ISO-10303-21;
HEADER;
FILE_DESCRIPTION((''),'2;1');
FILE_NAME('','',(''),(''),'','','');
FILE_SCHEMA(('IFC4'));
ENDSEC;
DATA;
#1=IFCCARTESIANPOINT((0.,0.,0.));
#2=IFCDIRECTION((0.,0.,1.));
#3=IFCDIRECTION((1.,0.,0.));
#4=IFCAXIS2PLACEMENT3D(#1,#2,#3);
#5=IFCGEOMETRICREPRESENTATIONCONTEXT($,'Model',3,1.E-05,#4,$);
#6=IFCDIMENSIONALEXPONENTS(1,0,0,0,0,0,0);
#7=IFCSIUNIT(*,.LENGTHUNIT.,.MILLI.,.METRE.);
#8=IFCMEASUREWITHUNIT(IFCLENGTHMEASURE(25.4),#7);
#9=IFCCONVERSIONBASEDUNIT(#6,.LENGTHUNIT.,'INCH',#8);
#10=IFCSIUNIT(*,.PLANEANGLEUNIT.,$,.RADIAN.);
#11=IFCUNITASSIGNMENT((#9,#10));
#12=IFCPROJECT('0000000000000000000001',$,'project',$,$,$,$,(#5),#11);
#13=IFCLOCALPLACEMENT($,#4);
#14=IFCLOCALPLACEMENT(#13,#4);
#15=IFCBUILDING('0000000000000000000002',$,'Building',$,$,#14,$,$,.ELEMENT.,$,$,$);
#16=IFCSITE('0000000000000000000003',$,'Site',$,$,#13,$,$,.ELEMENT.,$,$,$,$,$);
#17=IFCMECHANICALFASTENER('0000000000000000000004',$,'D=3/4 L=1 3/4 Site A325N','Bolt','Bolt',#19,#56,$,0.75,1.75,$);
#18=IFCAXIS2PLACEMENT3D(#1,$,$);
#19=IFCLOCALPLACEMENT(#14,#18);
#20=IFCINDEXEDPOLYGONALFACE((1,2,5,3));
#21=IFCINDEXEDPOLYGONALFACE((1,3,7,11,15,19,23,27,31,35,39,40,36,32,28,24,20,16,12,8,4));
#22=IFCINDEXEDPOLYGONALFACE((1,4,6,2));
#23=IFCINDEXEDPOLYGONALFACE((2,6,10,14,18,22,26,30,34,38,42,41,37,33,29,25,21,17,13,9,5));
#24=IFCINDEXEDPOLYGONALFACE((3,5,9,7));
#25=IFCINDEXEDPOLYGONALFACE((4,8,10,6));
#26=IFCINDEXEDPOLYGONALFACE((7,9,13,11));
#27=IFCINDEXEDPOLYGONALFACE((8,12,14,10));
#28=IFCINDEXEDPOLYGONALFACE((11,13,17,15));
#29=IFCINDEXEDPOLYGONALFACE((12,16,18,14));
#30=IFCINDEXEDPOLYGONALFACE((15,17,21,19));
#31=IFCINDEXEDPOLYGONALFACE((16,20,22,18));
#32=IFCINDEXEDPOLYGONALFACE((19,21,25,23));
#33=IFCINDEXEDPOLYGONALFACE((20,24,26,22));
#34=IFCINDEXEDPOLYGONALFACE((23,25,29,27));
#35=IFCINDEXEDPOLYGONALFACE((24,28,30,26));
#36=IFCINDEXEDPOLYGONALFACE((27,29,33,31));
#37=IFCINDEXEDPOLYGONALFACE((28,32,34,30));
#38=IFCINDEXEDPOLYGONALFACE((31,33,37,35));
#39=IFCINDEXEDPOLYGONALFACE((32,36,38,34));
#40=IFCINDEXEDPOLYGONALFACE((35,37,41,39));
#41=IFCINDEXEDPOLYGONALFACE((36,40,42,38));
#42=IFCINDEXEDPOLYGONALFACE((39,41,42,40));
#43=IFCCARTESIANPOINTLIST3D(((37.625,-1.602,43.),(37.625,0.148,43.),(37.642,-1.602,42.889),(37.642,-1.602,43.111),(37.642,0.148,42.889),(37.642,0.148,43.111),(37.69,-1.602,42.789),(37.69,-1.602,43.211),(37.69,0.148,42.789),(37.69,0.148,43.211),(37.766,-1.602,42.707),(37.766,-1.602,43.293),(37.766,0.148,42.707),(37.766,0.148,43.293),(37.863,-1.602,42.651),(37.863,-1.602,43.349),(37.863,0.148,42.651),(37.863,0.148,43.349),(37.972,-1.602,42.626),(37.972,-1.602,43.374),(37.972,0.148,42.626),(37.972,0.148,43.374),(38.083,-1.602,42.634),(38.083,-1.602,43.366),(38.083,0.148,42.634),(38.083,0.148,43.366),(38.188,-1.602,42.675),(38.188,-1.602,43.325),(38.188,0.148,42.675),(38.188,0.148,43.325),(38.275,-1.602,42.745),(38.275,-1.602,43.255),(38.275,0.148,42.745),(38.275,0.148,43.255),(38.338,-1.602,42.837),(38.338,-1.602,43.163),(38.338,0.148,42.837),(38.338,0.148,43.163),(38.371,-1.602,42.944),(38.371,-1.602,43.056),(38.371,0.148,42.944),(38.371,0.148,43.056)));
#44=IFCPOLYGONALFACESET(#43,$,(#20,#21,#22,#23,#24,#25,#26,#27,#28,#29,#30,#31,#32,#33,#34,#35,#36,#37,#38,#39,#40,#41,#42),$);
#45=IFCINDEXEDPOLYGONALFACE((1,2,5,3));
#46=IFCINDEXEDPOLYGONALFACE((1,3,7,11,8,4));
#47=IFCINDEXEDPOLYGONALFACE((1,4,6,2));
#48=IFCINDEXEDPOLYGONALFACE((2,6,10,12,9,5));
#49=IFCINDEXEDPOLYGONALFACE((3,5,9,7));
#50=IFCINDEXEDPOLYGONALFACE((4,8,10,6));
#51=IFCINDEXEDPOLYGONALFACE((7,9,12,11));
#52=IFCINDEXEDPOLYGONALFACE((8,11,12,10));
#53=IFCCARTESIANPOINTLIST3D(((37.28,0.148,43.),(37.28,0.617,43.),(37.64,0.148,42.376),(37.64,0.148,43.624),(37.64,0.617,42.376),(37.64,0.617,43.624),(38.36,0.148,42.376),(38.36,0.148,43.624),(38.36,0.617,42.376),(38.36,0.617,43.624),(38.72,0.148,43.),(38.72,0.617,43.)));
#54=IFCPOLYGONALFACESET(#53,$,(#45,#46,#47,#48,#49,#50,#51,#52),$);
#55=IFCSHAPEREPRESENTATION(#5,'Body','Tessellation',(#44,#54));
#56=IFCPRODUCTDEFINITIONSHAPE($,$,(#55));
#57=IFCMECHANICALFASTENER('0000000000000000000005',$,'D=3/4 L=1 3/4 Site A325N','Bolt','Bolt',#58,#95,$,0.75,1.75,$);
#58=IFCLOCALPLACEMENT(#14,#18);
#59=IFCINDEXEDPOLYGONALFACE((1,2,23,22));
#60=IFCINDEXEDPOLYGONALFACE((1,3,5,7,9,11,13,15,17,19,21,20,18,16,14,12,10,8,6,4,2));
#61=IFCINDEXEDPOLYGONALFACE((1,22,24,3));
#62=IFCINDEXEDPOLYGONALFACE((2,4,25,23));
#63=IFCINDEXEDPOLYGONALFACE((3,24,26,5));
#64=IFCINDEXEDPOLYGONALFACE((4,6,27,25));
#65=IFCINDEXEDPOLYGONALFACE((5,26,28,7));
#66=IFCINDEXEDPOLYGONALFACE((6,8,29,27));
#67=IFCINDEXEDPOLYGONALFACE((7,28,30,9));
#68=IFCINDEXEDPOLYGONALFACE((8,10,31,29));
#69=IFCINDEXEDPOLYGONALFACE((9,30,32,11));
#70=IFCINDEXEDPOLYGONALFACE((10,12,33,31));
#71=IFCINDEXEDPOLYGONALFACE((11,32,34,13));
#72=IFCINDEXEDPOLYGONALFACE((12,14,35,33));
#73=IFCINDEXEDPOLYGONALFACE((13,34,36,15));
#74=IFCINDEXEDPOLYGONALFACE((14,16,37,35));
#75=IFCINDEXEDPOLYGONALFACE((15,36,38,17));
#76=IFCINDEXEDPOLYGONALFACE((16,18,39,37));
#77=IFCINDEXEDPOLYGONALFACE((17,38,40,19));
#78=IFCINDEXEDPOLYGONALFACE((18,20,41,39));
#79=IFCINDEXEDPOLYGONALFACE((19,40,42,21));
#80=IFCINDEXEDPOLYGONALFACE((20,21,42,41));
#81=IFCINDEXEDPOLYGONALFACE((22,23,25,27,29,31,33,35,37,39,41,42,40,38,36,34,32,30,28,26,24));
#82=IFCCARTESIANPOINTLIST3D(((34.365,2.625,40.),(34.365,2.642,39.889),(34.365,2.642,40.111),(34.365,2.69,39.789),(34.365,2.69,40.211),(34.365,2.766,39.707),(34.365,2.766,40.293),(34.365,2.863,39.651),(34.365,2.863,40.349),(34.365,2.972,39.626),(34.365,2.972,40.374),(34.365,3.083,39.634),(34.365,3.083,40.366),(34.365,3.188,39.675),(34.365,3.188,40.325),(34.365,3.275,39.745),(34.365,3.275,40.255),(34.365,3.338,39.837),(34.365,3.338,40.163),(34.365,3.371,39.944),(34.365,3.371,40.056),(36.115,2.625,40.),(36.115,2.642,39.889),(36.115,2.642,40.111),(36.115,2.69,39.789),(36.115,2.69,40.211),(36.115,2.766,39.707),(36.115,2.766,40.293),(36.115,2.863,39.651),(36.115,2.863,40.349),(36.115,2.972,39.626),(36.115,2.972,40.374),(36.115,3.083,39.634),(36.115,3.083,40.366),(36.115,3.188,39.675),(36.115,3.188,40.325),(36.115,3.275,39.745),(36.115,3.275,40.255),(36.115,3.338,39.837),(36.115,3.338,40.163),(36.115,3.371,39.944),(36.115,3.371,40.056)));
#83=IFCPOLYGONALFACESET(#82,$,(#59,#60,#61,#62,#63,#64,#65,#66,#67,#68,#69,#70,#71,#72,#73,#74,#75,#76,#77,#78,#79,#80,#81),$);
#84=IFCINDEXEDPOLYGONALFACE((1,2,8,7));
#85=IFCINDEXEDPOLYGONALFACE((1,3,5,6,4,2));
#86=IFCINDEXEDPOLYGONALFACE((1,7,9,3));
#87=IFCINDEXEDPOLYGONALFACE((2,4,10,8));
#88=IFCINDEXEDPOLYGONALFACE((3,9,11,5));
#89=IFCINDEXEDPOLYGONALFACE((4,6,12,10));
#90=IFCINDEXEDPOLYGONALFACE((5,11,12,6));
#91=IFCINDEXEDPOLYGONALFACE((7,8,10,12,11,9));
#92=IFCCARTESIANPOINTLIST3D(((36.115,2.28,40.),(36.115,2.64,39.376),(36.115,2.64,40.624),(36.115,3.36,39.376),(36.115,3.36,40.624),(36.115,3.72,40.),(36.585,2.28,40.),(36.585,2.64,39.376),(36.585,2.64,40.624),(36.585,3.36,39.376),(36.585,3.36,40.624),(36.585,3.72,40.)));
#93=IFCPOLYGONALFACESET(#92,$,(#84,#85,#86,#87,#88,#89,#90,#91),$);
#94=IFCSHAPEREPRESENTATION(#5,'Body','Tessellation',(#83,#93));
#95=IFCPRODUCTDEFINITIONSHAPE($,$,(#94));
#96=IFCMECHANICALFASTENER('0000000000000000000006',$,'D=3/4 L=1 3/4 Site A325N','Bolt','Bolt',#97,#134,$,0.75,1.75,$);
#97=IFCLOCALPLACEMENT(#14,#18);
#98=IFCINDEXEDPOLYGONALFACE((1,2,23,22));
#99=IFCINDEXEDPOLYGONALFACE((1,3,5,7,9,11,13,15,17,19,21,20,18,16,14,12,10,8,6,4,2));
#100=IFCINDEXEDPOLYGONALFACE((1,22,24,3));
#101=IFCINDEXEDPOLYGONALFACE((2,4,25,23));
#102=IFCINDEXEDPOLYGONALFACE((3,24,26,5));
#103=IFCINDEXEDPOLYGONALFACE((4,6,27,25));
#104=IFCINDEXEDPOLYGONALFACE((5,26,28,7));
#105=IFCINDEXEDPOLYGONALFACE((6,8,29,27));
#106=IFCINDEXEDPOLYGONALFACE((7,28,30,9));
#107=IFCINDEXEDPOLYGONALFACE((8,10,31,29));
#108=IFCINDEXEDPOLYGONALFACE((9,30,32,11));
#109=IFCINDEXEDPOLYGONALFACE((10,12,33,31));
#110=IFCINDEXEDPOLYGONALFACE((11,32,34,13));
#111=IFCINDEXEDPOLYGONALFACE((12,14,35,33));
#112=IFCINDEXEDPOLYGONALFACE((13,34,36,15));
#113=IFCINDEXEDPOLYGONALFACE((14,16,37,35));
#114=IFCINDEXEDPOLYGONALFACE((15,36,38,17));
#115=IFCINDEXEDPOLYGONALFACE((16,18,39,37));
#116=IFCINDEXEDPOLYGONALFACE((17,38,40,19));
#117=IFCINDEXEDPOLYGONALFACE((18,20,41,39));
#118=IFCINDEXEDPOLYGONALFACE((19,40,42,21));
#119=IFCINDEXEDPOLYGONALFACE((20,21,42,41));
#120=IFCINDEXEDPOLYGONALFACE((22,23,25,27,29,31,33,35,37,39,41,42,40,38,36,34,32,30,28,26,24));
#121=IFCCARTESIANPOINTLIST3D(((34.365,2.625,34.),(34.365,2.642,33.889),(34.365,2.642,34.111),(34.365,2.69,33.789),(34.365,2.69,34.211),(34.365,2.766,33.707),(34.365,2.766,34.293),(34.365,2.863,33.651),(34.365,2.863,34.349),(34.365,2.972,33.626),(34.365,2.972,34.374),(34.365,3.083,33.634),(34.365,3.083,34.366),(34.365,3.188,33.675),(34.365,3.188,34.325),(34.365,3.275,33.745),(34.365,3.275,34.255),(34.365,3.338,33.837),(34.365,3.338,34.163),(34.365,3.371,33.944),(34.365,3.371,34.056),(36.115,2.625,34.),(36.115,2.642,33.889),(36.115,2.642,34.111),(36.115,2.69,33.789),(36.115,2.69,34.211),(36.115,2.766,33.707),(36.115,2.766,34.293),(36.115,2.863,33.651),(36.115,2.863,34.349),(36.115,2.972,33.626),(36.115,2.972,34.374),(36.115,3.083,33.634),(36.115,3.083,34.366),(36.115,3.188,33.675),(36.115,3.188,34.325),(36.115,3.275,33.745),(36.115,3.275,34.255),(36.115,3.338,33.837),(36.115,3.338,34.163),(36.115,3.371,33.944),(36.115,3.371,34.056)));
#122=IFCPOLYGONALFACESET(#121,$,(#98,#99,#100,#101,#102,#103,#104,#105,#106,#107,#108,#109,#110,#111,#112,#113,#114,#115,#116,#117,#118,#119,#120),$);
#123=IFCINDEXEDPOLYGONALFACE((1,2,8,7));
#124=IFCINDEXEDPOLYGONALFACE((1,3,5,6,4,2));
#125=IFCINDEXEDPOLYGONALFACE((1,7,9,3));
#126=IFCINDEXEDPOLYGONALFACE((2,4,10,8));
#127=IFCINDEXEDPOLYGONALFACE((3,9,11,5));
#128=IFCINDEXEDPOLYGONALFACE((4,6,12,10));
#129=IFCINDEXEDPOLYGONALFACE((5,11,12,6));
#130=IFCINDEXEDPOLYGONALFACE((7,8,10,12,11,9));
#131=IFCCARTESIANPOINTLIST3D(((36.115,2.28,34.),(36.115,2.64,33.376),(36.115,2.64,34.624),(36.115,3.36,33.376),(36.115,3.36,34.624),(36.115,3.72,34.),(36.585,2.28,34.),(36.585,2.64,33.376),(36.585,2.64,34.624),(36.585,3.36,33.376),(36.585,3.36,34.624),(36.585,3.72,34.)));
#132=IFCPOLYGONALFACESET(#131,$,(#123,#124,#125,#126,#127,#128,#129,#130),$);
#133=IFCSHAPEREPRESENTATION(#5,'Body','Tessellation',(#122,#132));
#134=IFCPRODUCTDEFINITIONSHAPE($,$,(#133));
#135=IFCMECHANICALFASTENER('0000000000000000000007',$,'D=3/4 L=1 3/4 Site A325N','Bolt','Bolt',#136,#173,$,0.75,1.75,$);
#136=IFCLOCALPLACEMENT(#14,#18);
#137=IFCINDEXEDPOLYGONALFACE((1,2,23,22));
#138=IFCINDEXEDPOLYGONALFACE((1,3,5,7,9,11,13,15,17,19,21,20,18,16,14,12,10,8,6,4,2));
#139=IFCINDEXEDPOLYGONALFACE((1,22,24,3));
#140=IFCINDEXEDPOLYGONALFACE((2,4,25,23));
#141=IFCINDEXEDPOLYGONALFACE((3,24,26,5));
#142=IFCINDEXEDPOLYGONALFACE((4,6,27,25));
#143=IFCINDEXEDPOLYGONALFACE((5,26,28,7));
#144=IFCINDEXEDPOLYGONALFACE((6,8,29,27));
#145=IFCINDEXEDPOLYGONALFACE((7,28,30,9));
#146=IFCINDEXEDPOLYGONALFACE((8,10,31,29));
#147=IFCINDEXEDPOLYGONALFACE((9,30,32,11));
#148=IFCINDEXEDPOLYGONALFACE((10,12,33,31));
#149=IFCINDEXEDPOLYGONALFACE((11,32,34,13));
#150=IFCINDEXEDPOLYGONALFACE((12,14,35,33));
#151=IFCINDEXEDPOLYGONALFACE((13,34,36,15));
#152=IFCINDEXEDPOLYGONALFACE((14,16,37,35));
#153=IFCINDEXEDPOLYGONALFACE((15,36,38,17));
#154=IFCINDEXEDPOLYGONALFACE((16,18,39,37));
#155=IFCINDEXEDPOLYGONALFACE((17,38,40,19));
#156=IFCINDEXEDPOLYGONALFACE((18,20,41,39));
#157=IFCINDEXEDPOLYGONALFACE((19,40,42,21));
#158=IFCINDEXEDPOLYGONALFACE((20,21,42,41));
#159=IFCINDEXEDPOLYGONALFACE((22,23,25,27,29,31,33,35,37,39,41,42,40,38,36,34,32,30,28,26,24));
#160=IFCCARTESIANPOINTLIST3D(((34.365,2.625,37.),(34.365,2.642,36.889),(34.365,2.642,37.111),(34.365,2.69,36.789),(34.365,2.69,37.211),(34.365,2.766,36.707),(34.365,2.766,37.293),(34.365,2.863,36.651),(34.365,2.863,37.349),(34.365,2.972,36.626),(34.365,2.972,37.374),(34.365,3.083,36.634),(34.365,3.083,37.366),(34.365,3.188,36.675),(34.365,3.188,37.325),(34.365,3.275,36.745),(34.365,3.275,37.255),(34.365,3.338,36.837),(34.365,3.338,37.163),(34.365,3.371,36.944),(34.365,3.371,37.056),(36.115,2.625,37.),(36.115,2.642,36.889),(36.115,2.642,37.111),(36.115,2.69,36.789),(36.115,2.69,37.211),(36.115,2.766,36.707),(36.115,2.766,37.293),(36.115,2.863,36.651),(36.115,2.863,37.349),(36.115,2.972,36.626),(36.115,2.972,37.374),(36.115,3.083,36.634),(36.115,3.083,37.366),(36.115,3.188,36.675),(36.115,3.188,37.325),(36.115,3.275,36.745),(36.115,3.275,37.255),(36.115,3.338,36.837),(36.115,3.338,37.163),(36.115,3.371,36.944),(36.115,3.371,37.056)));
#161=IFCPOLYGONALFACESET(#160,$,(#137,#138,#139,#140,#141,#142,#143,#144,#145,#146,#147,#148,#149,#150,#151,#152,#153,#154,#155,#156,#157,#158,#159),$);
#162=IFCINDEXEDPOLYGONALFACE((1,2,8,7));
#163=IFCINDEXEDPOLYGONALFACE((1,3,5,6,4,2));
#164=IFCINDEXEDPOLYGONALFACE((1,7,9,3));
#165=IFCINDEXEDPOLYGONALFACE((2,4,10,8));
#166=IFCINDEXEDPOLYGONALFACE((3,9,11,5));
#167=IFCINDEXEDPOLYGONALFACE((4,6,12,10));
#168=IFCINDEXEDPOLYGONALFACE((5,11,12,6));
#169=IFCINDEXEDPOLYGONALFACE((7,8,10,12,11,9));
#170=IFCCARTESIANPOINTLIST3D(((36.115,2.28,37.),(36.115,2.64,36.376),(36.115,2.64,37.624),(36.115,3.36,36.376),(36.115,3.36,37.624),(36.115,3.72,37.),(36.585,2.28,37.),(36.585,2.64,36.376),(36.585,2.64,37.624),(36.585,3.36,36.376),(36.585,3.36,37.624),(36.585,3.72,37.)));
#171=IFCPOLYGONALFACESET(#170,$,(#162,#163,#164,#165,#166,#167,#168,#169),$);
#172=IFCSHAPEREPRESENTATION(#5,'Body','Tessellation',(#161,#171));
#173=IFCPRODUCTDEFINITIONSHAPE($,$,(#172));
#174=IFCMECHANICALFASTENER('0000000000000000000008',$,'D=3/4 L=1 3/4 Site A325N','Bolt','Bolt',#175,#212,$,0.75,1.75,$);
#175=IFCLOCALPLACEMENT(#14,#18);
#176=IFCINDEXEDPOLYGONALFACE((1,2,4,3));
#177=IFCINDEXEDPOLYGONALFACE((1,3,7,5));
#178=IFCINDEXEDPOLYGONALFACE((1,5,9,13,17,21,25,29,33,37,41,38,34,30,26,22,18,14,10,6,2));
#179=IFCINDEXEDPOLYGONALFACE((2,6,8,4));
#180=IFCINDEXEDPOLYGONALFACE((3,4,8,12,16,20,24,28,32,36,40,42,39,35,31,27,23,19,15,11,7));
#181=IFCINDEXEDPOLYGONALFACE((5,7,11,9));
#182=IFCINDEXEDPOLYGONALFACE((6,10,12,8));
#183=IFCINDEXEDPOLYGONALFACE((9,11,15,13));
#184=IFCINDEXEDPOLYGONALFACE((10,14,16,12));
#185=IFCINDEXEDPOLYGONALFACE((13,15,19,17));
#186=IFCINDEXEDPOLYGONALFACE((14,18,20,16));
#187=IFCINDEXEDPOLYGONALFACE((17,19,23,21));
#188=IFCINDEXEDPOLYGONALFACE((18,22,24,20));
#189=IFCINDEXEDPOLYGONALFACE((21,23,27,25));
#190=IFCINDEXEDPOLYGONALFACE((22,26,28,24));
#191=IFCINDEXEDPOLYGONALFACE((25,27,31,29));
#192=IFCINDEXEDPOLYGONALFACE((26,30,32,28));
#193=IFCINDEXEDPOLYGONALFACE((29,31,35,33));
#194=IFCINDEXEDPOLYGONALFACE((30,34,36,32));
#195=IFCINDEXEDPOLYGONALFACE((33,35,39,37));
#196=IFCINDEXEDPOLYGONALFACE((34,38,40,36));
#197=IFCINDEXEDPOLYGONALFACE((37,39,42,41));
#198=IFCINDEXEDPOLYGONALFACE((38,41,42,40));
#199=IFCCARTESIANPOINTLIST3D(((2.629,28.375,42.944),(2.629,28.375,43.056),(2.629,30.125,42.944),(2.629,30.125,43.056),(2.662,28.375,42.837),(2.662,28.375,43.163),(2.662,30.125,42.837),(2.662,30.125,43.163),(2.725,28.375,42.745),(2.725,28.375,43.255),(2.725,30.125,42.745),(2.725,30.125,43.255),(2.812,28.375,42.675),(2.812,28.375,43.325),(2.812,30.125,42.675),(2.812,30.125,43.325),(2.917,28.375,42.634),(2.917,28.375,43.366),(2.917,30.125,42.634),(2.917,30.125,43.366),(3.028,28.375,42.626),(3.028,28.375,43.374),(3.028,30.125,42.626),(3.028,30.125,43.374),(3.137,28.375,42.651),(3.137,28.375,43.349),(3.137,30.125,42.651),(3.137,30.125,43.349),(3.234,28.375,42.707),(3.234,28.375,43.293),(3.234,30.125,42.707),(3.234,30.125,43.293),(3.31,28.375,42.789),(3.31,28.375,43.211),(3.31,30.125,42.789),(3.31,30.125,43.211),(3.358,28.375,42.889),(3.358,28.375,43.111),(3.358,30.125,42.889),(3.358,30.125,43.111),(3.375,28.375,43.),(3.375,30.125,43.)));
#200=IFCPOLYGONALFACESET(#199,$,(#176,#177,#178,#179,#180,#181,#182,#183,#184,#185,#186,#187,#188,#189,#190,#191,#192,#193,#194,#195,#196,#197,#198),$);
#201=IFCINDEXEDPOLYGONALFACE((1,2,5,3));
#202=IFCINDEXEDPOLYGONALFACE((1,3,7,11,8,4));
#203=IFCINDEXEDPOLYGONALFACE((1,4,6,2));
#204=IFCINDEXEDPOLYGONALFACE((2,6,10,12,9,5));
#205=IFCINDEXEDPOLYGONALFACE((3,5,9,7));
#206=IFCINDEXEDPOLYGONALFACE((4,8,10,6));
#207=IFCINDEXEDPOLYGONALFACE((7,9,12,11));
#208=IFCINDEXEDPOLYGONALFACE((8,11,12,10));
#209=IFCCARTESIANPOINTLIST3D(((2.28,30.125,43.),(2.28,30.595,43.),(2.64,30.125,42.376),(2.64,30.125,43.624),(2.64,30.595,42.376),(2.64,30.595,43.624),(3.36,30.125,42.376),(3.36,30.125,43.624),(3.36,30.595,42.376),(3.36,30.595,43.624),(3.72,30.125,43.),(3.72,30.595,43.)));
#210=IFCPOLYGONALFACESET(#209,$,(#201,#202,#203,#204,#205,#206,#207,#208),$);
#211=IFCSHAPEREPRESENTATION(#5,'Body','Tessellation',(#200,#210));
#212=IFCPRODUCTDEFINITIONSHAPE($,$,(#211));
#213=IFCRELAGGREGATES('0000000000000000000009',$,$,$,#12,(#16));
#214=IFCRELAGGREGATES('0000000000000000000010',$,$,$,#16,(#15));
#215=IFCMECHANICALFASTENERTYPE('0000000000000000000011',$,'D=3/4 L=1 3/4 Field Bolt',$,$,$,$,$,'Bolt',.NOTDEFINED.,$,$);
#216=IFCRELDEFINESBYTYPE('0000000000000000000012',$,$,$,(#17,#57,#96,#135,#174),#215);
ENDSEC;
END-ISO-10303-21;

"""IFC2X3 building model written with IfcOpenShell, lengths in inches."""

from ifc_helpers import new_model, entity, si_unit, converted_unit, frame, origin_with_axes, origin_2d_with_axis, place, context, project, spatial, polyline, circle, outline, extrude, source, transform, mapped, type_object, type_shapes, element, save


model = new_model("IFC2X3")

# Units and contexts
model_context = context("Model", 3, precision=1e-05, world=origin_with_axes())
ifc_project = project(units=[converted_unit("LENGTHUNIT", "INCH", entity("IfcLengthMeasure", 25.4), si_unit("LENGTHUNIT", "METRE", prefix="MILLI"), dimensions=[1, 0, 0, 0, 0, 0, 0]), si_unit("PLANEANGLEUNIT", "RADIAN")], contexts=[model_context])

# Site, building
site_placement = place(None, origin_with_axes())
site = spatial("IfcSite", under=ifc_project, at=site_placement, Name="Site", CompositionType="ELEMENT")
building_placement = place(site_placement, origin_with_axes())
building = spatial("IfcBuilding", under=site, at=building_placement, Name="Building", CompositionType="ELEMENT")

# Mechanical fasteners
mechanical_fastener_type_1 = type_object("IfcMechanicalFastenerType", Name="D=3/4 L=1 3/4 Field Bolt", ElementType="Bolt")
shared_shape_1 = source(origin_with_axes(), model_context, "Body", "SweptSolid", [
    extrude(circle(Radius=0.375, at=origin_2d_with_axis()), frame((0.0, 0.0, 0.0), z_axis=(1.0, 0.0, 0.0), x_axis=(0.0, 1.0, 0.0)), (0.0, 0.0, 1.0), 1.75),
    extrude(outline(polyline([(-0.72, 0.0), (-0.36, 0.624), (0.36, 0.624), (0.72, 0.0), (0.36, -0.624), (-0.36, -0.624), (-0.72, 0.0)])), frame((0.0, 0.0, 0.0), z_axis=(1.0, 0.0, 0.0), x_axis=(0.0, 1.0, 0.0)), (0.0, 0.0, -1.0), 0.47),
])
type_shapes(mechanical_fastener_type_1, [shared_shape_1])
placement_1 = place(building_placement, frame((36.0, 0.0, 46.0), z_axis=(0.0, 0.0, 1.0), x_axis=(0.0, -1.0, 0.0)))
placement_2 = place(placement_1, frame((-0.148, -2.0, -3.0), z_axis=(0.0, 0.0, -1.0), x_axis=(1.0, 0.0, 0.0)))
for number, where, z_axis, x_axis, name in (
    (1, (0.0, -4.0, 0.0), (0.0, 0.0, 1.0), (1.0, 0.0, 0.0), "D=3/4 L=1 3/4 Site A325N"),
):
    element("IfcMechanicalFastener", number, at=place(placement_2, frame(where, z_axis=z_axis, x_axis=x_axis)), type_object=mechanical_fastener_type_1, Name=name, Description="Bolt", ObjectType="Bolt", NominalDiameter=0.75, NominalLength=1.75, context=model_context, shape_type="MappedRepresentation", body=[
        mapped(shared_shape_1, transform((0.0, 0.0, 0.0), scale=1.0)),
    ])
placement_3 = place(building_placement, frame((36.0, 0.0, 43.0), z_axis=(0.0, 0.0, 1.0), x_axis=(0.0, 1.0, 0.0)))
placement_4 = place(placement_3, frame((3.0, -0.115, -3.0), z_axis=(0.0, 0.0, 1.0), x_axis=(0.0, 1.0, 0.0)))
for number, where, z_axis, x_axis, name in (
    (2, (0.0, 0.0, 0.0), (0.0, 0.0, 1.0), (1.0, 0.0, 0.0), "D=3/4 L=1 3/4 Site A325N"),
    (3, (0.0, 0.0, -6.0), (0.0, 0.0, 1.0), (1.0, 0.0, 0.0), "D=3/4 L=1 3/4 Site A325N"),
    (4, (0.0, 0.0, -3.0), (0.0, 0.0, 1.0), (1.0, 0.0, 0.0), "D=3/4 L=1 3/4 Site A325N"),
):
    element("IfcMechanicalFastener", number, at=place(placement_4, frame(where, z_axis=z_axis, x_axis=x_axis)), type_object=mechanical_fastener_type_1, Name=name, Description="Bolt", ObjectType="Bolt", NominalDiameter=0.75, NominalLength=1.75, context=model_context, shape_type="MappedRepresentation", body=[
        mapped(shared_shape_1, transform((0.0, 0.0, 0.0), scale=1.0)),
    ])
placement_5 = place(building_placement, frame((0.0, 30.0, 46.0), z_axis=(0.0, 0.0, 1.0), x_axis=(1.0, 0.0, 0.0)))
placement_6 = place(placement_5, frame((3.0, 0.125, -3.0), z_axis=(0.0, 0.0, 1.0), x_axis=(0.0, -1.0, 0.0)))
for number, where, z_axis, x_axis, name in (
    (5, (0.0, 0.0, 0.0), (0.0, 0.0, 1.0), (1.0, 0.0, 0.0), "D=3/4 L=1 3/4 Site A325N"),
):
    element("IfcMechanicalFastener", number, at=place(placement_6, frame(where, z_axis=z_axis, x_axis=x_axis)), type_object=mechanical_fastener_type_1, Name=name, Description="Bolt", ObjectType="Bolt", NominalDiameter=0.75, NominalLength=1.75, context=model_context, shape_type="MappedRepresentation", body=[
        mapped(shared_shape_1, transform((0.0, 0.0, 0.0), scale=1.0)),
    ])

save(model, "model.ifc")
